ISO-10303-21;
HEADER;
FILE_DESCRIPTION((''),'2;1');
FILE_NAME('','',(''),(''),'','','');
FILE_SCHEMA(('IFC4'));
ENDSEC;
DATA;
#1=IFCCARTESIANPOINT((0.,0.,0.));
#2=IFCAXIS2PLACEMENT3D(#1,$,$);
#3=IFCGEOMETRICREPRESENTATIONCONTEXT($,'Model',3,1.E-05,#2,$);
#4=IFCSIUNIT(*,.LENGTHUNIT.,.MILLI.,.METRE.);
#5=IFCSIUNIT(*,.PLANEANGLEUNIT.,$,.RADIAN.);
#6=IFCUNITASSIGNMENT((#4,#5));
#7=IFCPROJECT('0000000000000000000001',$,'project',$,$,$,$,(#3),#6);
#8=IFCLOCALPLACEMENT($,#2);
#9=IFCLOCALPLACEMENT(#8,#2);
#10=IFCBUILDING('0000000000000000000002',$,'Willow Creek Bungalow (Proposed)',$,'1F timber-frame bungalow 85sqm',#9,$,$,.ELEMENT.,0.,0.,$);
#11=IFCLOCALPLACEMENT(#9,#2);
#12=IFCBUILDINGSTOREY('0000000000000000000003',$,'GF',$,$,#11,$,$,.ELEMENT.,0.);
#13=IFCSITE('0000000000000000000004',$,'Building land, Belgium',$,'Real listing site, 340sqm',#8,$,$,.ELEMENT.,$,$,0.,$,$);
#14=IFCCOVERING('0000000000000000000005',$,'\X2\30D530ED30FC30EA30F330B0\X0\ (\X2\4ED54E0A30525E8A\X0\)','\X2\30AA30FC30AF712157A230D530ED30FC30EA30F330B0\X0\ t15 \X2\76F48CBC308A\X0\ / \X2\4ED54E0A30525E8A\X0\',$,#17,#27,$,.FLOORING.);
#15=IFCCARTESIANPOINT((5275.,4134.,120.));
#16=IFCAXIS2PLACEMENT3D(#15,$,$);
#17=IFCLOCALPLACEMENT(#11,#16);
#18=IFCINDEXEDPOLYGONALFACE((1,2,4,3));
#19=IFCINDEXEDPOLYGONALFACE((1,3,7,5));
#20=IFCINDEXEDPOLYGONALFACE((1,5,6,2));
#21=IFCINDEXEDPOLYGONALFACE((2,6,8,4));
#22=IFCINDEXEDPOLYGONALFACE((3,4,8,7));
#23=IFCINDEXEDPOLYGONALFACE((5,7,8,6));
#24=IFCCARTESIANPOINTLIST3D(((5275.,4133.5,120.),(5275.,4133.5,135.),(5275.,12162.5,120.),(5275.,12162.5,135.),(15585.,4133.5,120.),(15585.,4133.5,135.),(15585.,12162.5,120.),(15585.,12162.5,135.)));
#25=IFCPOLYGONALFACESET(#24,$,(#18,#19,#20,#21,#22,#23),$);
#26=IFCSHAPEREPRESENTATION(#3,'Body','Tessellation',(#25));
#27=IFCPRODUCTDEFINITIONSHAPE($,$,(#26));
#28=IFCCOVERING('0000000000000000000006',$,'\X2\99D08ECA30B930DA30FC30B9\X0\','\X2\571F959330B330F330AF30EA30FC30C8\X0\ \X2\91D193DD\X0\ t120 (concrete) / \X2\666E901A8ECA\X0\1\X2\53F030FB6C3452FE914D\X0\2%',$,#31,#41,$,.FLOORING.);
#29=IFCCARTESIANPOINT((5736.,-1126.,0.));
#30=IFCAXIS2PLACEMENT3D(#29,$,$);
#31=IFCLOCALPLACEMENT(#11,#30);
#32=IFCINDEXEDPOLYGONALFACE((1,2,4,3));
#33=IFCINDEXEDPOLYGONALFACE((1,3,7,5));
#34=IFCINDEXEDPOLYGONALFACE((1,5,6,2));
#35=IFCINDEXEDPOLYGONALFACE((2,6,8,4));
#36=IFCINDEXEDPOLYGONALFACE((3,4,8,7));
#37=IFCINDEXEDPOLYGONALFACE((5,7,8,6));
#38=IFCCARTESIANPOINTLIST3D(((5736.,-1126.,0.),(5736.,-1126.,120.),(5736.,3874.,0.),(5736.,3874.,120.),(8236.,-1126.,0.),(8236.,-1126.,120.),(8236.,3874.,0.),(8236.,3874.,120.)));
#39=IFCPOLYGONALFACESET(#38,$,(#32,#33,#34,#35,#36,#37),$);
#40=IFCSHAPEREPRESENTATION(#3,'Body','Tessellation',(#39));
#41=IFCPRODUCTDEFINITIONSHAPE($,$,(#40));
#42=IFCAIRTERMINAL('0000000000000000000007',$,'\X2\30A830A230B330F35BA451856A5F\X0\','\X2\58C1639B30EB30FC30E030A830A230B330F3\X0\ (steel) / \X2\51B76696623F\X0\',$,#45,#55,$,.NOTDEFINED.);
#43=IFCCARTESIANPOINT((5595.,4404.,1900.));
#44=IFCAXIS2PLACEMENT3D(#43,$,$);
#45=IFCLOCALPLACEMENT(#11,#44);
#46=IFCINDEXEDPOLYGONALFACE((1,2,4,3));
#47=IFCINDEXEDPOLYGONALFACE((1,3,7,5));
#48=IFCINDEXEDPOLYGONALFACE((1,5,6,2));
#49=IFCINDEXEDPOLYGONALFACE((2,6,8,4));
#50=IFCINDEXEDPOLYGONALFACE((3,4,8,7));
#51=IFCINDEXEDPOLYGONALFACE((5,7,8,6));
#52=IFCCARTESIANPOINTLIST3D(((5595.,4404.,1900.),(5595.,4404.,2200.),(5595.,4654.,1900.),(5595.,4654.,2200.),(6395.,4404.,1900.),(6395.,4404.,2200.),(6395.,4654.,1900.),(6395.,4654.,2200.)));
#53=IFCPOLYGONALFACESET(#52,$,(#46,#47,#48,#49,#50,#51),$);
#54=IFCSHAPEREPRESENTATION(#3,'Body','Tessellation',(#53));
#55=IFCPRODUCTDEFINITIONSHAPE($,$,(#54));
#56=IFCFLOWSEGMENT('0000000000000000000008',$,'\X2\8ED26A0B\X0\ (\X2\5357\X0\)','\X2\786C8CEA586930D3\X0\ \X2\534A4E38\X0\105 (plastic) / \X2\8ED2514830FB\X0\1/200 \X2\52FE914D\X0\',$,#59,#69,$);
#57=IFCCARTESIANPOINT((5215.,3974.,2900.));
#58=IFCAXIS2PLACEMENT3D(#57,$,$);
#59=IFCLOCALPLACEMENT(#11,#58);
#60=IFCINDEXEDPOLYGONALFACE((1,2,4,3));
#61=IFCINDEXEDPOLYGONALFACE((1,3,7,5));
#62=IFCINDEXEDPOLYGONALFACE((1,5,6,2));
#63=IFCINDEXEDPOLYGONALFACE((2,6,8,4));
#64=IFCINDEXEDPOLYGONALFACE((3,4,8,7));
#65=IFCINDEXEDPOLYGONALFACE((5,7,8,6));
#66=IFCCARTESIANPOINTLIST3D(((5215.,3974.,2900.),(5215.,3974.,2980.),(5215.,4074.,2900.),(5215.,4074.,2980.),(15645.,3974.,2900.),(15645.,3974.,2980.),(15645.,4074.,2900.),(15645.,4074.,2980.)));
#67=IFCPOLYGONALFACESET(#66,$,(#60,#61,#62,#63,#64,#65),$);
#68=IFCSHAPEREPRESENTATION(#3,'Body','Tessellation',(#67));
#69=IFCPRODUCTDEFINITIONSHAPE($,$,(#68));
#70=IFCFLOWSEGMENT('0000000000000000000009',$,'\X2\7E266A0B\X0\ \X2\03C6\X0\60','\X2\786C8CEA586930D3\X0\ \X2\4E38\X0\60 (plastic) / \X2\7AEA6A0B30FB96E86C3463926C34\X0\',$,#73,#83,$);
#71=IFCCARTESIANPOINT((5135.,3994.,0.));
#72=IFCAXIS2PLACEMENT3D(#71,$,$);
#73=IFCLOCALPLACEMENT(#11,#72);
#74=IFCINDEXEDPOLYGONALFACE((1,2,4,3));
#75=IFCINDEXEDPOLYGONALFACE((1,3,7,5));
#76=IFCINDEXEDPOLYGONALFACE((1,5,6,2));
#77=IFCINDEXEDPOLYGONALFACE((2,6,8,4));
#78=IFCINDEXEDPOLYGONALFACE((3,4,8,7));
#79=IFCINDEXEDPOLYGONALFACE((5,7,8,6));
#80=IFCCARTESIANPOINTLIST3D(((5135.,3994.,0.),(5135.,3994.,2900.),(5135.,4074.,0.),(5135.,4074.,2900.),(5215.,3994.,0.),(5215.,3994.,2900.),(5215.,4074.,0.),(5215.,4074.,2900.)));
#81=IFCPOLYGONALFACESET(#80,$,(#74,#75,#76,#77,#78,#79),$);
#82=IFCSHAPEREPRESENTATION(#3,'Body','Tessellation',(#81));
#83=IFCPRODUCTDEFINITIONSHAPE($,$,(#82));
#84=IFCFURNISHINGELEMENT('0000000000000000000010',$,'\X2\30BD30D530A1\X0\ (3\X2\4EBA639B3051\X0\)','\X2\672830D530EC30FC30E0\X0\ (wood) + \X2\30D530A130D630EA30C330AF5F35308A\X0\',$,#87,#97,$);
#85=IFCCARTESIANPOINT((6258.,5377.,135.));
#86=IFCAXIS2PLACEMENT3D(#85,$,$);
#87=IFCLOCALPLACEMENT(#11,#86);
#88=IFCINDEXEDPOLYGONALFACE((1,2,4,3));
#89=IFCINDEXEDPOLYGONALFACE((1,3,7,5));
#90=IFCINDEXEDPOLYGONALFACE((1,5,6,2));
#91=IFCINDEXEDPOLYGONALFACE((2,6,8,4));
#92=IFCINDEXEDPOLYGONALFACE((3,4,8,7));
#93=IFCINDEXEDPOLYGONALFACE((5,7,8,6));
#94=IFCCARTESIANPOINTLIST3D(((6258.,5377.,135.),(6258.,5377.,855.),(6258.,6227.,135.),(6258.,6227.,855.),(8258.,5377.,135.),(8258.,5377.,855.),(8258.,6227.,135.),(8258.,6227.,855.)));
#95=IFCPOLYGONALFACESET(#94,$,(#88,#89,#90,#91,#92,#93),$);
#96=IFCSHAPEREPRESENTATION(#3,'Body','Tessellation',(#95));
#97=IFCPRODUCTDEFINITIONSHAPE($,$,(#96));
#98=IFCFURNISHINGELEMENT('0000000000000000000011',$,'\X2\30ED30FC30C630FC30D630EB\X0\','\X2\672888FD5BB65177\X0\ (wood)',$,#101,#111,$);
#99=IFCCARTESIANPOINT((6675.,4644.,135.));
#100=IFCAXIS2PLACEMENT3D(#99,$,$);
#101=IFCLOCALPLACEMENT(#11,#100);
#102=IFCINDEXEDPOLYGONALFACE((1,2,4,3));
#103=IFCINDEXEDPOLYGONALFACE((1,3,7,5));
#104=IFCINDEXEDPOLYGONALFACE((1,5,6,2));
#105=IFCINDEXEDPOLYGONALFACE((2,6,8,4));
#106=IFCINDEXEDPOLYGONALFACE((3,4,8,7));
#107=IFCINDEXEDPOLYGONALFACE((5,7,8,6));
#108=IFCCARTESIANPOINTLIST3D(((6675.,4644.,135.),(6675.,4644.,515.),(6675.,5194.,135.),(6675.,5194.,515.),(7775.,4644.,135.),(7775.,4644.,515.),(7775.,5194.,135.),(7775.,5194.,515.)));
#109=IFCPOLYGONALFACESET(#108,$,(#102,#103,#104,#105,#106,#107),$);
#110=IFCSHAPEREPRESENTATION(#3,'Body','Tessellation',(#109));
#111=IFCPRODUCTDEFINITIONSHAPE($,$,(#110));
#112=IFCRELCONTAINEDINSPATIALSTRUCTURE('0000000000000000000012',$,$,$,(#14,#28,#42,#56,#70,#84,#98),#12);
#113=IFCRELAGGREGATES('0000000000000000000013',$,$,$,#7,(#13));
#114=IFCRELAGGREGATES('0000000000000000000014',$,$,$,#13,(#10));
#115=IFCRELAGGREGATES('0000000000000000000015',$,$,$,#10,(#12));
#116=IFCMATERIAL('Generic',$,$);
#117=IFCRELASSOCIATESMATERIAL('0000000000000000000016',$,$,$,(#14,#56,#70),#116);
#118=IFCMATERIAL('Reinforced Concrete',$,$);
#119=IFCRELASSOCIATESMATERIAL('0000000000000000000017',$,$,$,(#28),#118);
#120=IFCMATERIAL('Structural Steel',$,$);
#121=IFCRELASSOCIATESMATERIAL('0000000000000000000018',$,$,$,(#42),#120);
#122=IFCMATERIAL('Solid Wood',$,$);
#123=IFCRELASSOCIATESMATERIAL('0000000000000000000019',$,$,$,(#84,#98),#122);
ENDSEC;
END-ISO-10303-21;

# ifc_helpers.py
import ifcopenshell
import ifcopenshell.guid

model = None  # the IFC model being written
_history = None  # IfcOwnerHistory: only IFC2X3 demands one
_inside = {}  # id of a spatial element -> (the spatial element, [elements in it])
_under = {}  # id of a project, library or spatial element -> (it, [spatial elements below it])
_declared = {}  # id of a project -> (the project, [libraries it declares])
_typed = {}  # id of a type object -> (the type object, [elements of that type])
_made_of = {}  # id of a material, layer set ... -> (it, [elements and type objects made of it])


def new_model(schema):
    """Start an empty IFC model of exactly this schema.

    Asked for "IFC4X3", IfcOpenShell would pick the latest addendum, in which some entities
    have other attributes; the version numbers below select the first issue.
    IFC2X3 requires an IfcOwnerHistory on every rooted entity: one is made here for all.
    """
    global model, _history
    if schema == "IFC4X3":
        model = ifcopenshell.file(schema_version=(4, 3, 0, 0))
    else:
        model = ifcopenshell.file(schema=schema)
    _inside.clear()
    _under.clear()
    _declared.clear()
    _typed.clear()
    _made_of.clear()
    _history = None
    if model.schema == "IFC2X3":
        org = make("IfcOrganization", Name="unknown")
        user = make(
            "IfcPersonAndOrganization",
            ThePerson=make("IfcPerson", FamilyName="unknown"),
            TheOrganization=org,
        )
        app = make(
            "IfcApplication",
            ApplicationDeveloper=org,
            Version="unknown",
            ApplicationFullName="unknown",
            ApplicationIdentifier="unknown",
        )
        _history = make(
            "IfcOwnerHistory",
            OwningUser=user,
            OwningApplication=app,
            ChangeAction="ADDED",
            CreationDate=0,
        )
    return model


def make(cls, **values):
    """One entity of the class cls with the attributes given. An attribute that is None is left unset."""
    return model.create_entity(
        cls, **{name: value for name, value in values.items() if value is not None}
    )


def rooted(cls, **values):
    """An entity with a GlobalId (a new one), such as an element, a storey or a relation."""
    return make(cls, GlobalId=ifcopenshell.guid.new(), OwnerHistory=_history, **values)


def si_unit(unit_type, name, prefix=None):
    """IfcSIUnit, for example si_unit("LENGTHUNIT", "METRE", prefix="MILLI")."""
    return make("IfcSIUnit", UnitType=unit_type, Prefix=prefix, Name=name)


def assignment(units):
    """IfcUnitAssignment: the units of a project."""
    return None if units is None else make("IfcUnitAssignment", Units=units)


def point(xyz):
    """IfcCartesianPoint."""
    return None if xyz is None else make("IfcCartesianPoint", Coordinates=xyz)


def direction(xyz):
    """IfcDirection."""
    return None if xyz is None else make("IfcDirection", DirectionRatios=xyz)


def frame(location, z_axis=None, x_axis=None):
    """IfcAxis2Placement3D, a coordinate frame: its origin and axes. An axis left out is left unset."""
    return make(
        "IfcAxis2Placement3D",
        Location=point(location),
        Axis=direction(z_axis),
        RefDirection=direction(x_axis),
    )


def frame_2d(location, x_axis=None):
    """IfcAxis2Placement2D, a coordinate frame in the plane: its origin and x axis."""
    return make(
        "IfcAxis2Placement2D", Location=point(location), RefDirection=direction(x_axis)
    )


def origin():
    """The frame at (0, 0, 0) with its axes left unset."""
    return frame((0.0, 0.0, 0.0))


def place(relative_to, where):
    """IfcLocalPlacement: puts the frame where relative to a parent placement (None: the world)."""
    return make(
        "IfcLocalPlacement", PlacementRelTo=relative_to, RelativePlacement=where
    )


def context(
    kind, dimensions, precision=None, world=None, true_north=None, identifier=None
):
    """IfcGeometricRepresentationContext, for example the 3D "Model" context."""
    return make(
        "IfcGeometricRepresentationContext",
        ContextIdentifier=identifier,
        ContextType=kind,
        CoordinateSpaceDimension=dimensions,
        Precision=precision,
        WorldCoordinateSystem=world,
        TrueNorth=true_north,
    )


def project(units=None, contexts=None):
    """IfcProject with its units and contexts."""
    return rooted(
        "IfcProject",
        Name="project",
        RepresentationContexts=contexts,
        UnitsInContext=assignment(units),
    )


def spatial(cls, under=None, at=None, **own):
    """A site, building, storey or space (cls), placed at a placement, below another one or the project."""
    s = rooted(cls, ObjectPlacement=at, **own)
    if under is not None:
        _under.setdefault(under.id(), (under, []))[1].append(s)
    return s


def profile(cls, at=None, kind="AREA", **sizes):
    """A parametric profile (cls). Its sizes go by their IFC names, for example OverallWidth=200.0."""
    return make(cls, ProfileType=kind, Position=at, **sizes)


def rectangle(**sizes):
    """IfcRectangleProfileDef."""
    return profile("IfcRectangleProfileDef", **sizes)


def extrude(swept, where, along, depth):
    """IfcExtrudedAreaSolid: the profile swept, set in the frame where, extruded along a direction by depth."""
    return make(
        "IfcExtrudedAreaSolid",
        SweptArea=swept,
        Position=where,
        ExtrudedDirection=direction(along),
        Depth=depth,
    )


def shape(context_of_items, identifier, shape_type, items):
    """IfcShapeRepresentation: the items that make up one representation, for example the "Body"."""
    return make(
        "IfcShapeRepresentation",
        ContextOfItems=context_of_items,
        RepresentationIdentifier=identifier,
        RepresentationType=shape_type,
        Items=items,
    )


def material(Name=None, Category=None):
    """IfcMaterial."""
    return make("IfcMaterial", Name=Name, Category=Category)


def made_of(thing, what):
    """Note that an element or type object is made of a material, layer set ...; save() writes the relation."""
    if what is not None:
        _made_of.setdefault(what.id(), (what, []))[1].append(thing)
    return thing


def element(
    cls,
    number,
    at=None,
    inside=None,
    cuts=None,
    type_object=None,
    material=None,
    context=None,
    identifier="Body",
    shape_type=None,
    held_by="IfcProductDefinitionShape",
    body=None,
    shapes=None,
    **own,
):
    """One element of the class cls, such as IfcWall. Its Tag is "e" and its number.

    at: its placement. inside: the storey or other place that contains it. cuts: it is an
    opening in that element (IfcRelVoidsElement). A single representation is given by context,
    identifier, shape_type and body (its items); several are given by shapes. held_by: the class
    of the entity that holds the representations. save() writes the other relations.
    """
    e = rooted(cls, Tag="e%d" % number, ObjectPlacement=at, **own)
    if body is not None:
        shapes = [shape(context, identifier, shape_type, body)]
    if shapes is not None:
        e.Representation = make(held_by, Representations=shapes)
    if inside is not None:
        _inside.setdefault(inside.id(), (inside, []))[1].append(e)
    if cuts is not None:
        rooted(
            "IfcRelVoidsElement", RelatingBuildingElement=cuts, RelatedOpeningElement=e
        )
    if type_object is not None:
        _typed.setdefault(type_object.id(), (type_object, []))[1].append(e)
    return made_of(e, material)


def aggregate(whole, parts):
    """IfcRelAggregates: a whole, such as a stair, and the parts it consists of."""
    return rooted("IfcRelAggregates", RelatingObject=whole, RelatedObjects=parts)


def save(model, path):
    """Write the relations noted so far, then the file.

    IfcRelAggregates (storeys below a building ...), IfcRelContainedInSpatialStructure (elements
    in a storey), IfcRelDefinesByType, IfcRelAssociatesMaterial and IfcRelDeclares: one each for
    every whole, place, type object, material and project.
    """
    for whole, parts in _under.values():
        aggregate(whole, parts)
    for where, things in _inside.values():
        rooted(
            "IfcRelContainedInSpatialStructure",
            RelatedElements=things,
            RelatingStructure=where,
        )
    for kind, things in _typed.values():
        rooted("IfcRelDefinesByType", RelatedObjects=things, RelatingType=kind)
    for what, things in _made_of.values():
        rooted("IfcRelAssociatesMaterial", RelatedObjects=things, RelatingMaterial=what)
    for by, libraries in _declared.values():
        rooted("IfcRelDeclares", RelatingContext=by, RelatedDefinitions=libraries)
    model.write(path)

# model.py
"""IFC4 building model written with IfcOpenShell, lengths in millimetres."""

from ifc_helpers import new_model, si_unit, frame, frame_2d, origin, place, context, project, spatial, rectangle, extrude, material, element, save


model = new_model("IFC4")

# Units and contexts
model_context = context("Model", 3, precision=1e-05, world=origin())
ifc_project = project(units=[si_unit("LENGTHUNIT", "METRE", prefix="MILLI"), si_unit("PLANEANGLEUNIT", "RADIAN")], contexts=[model_context])

# Site, building, storey
site_placement = place(None, origin())
site = spatial("IfcSite", under=ifc_project, at=site_placement, Name="Building land, Belgium", ObjectType="Real listing site, 340sqm", CompositionType="ELEMENT", RefElevation=0.0)
building_placement = place(site_placement, origin())
building = spatial("IfcBuilding", under=site, at=building_placement, Name="Willow Creek Bungalow (Proposed)", ObjectType="1F timber-frame bungalow 85sqm", CompositionType="ELEMENT", ElevationOfRefHeight=0.0, ElevationOfTerrain=0.0)
storey_placement = place(building_placement, origin())
storey = spatial("IfcBuildingStorey", under=building, at=storey_placement, Name="GF", CompositionType="ELEMENT", Elevation=0.0)

# Shared definitions
ifc_material_1 = material(Name="Solid Wood")

# Shared definitions
ifc_material_2 = material(Name="Reinforced Concrete")

# Shared definitions
ifc_material_3 = material(Name="Structural Steel")

# Coverings
ifc_material_4 = material(Name="Generic")
covering_1_placement = place(storey_placement, frame((5275.0, 4134.0, 120.0)))
element("IfcCovering", 1, at=covering_1_placement, inside=storey, material=ifc_material_4, Name="フローリング (仕上げ床)", Description="オーク無垢フローリング t15 直貼り / 仕上げ床", PredefinedType="FLOORING", context=model_context, shape_type="SweptSolid", body=[
    extrude(rectangle(XDim=10310.0, YDim=8029.0, at=frame_2d((5155.0, 4014.0))), frame((5275.0, 4134.0, 120.0)), (0.0, 0.0, 1.0), 15.0),
])
covering_2_placement = place(storey_placement, frame((5736.0, -1126.0, 0.0)))
element("IfcCovering", 2, at=covering_2_placement, inside=storey, material=ifc_material_2, Name="駐車スペース", Description="土間コンクリート 金鏝 t120 (concrete) / 普通車1台・水勾配2%", PredefinedType="FLOORING", context=model_context, shape_type="SweptSolid", body=[
    extrude(rectangle(XDim=2500.0, YDim=5000.0, at=frame_2d((1250.0, 2500.0))), frame((5736.0, -1126.0, 0.0)), (0.0, 0.0, 1.0), 120.0),
])

# Air terminal
air_terminal_placement = place(storey_placement, frame((5595.0, 4404.0, 1900.0)))
element("IfcAirTerminal", 3, at=air_terminal_placement, inside=storey, material=ifc_material_3, Name="エアコン室内機", Description="壁掛ルームエアコン (steel) / 冷暖房", PredefinedType="NOTDEFINED", context=model_context, shape_type="SweptSolid", body=[
    extrude(rectangle(XDim=800.0, YDim=250.0, at=frame_2d((400.0, 125.0))), frame((5595.0, 4404.0, 1900.0)), (0.0, 0.0, 1.0), 300.0),
])

# Flow segments
flow_segment_1_placement = place(storey_placement, frame((5215.0, 3974.0, 2900.0)))
element("IfcFlowSegment", 4, at=flow_segment_1_placement, inside=storey, material=ifc_material_4, Name="軒樋 (南)", Description="硬質塩ビ 半丸105 (plastic) / 軒先・1/200 勾配", context=model_context, shape_type="SweptSolid", body=[
    extrude(rectangle(XDim=10430.0, YDim=100.0, at=frame_2d((5215.0, 50.0))), frame((5215.0, 3974.0, 2900.0)), (0.0, 0.0, 1.0), 80.0),
])
flow_segment_2_placement = place(storey_placement, frame((5135.0, 3994.0, 0.0)))
element("IfcFlowSegment", 5, at=flow_segment_2_placement, inside=storey, material=ifc_material_4, Name="縦樋 φ60", Description="硬質塩ビ 丸60 (plastic) / 竪樋・雨水排水", context=model_context, shape_type="SweptSolid", body=[
    extrude(rectangle(XDim=80.0, YDim=80.0, at=frame_2d((40.0, 40.0))), frame((5135.0, 3994.0, 0.0)), (0.0, 0.0, 1.0), 2900.0),
])

# Furnishing elements
furnishing_1_placement = place(storey_placement, frame((6258.0, 5377.0, 135.0)))
element("IfcFurnishingElement", 6, at=furnishing_1_placement, inside=storey, material=ifc_material_1, Name="ソファ (3人掛け)", Description="木フレーム (wood) + ファブリック張り", context=model_context, shape_type="SweptSolid", body=[
    extrude(rectangle(XDim=2000.0, YDim=850.0, at=frame_2d((1000.0, 425.0))), frame((6258.0, 5377.0, 135.0)), (0.0, 0.0, 1.0), 720.0),
])
furnishing_2_placement = place(storey_placement, frame((6675.0, 4644.0, 135.0)))
element("IfcFurnishingElement", 7, at=furnishing_2_placement, inside=storey, material=ifc_material_1, Name="ローテーブル", Description="木製家具 (wood)", context=model_context, shape_type="SweptSolid", body=[
    extrude(rectangle(XDim=1100.0, YDim=550.0, at=frame_2d((550.0, 275.0))), frame((6675.0, 4644.0, 135.0)), (0.0, 0.0, 1.0), 380.0),
])

save(model, "model.ifc")
